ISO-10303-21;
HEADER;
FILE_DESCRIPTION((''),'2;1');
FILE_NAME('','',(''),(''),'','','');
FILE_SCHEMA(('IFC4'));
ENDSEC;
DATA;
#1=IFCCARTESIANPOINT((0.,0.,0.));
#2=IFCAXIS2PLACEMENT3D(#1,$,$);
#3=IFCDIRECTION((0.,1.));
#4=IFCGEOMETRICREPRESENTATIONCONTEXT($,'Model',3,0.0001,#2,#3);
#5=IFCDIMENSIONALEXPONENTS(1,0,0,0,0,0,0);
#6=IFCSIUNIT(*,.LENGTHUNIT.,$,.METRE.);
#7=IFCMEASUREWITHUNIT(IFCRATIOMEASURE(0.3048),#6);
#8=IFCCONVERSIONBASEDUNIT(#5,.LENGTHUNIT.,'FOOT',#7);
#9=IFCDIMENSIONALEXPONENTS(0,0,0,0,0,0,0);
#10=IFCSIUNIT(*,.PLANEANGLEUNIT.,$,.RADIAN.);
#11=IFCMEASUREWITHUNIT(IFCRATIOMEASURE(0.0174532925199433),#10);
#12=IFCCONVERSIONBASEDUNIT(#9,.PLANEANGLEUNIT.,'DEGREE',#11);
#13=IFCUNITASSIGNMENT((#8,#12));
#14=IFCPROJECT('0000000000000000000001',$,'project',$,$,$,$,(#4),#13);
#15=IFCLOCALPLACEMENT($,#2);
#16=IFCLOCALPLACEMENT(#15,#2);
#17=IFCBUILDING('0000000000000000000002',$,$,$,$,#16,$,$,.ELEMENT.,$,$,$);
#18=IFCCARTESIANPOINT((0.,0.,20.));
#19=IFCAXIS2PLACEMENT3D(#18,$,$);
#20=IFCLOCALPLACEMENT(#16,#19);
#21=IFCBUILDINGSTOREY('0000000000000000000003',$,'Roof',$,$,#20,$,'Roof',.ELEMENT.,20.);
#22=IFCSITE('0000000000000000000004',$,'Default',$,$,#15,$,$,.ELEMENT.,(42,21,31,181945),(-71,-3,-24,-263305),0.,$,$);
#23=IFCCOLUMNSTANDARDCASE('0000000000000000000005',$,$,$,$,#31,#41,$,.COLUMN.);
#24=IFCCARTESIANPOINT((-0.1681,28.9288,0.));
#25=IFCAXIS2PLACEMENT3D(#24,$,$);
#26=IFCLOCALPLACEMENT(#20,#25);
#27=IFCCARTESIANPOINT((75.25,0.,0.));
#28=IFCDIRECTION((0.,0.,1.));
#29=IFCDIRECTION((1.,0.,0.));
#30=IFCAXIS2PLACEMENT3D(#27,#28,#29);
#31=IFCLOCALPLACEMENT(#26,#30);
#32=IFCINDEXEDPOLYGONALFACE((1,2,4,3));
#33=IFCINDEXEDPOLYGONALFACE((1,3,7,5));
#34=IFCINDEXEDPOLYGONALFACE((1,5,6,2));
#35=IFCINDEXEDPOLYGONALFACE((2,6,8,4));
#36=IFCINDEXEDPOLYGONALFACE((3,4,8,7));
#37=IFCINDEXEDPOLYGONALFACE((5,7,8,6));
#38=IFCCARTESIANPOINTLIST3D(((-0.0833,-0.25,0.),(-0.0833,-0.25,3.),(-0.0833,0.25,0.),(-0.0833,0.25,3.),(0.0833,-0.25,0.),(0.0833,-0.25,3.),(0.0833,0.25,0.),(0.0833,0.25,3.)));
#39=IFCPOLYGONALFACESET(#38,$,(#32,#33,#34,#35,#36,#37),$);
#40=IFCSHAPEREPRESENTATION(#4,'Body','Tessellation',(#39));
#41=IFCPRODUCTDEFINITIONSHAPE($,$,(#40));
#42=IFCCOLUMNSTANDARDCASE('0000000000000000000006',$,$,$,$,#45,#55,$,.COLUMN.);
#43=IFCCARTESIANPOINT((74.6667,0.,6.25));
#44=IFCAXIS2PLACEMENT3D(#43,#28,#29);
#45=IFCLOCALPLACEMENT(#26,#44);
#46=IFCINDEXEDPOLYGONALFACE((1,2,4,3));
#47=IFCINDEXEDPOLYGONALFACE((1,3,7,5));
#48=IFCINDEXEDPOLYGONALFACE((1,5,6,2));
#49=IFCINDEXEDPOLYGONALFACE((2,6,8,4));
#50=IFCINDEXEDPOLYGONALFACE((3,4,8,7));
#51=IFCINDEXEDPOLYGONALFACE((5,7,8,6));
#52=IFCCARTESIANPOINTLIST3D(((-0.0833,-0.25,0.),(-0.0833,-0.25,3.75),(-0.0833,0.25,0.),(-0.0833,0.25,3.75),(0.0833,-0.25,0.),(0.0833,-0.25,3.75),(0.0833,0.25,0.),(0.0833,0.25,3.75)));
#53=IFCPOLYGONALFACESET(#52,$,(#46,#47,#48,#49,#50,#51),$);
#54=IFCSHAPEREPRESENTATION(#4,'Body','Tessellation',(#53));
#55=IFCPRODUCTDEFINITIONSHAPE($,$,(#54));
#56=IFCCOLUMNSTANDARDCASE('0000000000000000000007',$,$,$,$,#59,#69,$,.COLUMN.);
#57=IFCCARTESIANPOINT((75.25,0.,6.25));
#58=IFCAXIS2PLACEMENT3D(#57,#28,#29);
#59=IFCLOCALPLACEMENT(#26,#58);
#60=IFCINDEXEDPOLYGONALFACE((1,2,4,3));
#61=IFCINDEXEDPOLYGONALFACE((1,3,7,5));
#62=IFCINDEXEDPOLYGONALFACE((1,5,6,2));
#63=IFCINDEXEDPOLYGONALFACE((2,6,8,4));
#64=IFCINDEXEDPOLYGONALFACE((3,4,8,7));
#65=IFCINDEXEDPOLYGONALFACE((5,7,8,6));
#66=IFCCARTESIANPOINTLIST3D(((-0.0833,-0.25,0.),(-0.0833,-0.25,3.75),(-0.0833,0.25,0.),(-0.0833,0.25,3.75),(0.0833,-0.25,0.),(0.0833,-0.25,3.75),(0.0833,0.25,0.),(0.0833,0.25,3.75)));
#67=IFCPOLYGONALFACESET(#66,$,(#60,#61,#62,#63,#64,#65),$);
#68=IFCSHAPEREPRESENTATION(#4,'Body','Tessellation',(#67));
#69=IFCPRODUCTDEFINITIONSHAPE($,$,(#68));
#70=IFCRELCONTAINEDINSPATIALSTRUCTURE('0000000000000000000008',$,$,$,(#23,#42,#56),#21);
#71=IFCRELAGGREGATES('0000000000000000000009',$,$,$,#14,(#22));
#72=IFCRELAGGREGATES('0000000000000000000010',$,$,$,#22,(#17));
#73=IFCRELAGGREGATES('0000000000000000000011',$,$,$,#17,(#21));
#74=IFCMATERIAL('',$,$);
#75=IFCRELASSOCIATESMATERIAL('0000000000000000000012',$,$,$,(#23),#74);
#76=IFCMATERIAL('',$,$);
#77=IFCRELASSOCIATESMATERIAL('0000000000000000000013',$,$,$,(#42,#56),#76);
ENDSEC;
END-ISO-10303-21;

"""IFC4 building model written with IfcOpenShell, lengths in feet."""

from ifc_helpers import new_model, entity, si_unit, converted_unit, direction, frame, origin, place, context, project, spatial, rectangle, extrude, material, element, save


model = new_model("IFC4")

# Units and contexts
model_context = context("Model", 3, precision=0.0001, world=origin(), true_north=direction((0.0, 1.0)))
ifc_project = project(units=[converted_unit("LENGTHUNIT", "FOOT", entity("IfcRatioMeasure", 0.3048), si_unit("LENGTHUNIT", "METRE"), dimensions=[1, 0, 0, 0, 0, 0, 0]), converted_unit("PLANEANGLEUNIT", "DEGREE", entity("IfcRatioMeasure", 0.0174532925199433), si_unit("PLANEANGLEUNIT", "RADIAN"), dimensions=[0, 0, 0, 0, 0, 0, 0])], contexts=[model_context])

# Site, building, storey
site_placement = place(None, origin())
site = spatial("IfcSite", under=ifc_project, at=site_placement, Name="Default", CompositionType="ELEMENT", RefLatitude=(42, 21, 31, 181945), RefLongitude=(-71, -3, -24, -263305), RefElevation=0.0)
building_placement = place(site_placement, origin())
building = spatial("IfcBuilding", under=site, at=building_placement, CompositionType="ELEMENT")
storey_placement = place(building_placement, frame((0.0, 0.0, 20.0)))
storey = spatial("IfcBuildingStorey", under=building, at=storey_placement, Name="Roof", LongName="Roof", CompositionType="ELEMENT", Elevation=20.0)

# Columns
ifc_material_1 = material(Name="")
placement = place(storey_placement, frame((-0.1681, 28.9288, 0.0)))
for number, where, z_axis, x_axis in (
    (1, (75.25, 0.0, 0.0), (0.0, 0.0, 1.0), (1.0, 0.0, 0.0)),
):
    element("IfcColumnStandardCase", number, at=place(placement, frame(where, z_axis=z_axis, x_axis=x_axis)), inside=storey, material=ifc_material_1, PredefinedType="COLUMN", context=model_context, shape_type="SweptSolid", body=[
        extrude(rectangle(XDim=0.1667, YDim=0.5), origin(), (0.0, 0.0, 1.0), 3.0),
    ])
ifc_material_2 = material(Name="")
for number, where, z_axis, x_axis in (
    (2, (74.6667, 0.0, 6.25), (0.0, 0.0, 1.0), (1.0, 0.0, 0.0)),
    (3, (75.25, 0.0, 6.25), (0.0, 0.0, 1.0), (1.0, 0.0, 0.0)),
):
    element("IfcColumnStandardCase", number, at=place(placement, frame(where, z_axis=z_axis, x_axis=x_axis)), inside=storey, material=ifc_material_2, PredefinedType="COLUMN", context=model_context, shape_type="SweptSolid", body=[
        extrude(rectangle(XDim=0.1667, YDim=0.5), origin(), (0.0, 0.0, 1.0), 3.75),
    ])

save(model, "model.ifc")
